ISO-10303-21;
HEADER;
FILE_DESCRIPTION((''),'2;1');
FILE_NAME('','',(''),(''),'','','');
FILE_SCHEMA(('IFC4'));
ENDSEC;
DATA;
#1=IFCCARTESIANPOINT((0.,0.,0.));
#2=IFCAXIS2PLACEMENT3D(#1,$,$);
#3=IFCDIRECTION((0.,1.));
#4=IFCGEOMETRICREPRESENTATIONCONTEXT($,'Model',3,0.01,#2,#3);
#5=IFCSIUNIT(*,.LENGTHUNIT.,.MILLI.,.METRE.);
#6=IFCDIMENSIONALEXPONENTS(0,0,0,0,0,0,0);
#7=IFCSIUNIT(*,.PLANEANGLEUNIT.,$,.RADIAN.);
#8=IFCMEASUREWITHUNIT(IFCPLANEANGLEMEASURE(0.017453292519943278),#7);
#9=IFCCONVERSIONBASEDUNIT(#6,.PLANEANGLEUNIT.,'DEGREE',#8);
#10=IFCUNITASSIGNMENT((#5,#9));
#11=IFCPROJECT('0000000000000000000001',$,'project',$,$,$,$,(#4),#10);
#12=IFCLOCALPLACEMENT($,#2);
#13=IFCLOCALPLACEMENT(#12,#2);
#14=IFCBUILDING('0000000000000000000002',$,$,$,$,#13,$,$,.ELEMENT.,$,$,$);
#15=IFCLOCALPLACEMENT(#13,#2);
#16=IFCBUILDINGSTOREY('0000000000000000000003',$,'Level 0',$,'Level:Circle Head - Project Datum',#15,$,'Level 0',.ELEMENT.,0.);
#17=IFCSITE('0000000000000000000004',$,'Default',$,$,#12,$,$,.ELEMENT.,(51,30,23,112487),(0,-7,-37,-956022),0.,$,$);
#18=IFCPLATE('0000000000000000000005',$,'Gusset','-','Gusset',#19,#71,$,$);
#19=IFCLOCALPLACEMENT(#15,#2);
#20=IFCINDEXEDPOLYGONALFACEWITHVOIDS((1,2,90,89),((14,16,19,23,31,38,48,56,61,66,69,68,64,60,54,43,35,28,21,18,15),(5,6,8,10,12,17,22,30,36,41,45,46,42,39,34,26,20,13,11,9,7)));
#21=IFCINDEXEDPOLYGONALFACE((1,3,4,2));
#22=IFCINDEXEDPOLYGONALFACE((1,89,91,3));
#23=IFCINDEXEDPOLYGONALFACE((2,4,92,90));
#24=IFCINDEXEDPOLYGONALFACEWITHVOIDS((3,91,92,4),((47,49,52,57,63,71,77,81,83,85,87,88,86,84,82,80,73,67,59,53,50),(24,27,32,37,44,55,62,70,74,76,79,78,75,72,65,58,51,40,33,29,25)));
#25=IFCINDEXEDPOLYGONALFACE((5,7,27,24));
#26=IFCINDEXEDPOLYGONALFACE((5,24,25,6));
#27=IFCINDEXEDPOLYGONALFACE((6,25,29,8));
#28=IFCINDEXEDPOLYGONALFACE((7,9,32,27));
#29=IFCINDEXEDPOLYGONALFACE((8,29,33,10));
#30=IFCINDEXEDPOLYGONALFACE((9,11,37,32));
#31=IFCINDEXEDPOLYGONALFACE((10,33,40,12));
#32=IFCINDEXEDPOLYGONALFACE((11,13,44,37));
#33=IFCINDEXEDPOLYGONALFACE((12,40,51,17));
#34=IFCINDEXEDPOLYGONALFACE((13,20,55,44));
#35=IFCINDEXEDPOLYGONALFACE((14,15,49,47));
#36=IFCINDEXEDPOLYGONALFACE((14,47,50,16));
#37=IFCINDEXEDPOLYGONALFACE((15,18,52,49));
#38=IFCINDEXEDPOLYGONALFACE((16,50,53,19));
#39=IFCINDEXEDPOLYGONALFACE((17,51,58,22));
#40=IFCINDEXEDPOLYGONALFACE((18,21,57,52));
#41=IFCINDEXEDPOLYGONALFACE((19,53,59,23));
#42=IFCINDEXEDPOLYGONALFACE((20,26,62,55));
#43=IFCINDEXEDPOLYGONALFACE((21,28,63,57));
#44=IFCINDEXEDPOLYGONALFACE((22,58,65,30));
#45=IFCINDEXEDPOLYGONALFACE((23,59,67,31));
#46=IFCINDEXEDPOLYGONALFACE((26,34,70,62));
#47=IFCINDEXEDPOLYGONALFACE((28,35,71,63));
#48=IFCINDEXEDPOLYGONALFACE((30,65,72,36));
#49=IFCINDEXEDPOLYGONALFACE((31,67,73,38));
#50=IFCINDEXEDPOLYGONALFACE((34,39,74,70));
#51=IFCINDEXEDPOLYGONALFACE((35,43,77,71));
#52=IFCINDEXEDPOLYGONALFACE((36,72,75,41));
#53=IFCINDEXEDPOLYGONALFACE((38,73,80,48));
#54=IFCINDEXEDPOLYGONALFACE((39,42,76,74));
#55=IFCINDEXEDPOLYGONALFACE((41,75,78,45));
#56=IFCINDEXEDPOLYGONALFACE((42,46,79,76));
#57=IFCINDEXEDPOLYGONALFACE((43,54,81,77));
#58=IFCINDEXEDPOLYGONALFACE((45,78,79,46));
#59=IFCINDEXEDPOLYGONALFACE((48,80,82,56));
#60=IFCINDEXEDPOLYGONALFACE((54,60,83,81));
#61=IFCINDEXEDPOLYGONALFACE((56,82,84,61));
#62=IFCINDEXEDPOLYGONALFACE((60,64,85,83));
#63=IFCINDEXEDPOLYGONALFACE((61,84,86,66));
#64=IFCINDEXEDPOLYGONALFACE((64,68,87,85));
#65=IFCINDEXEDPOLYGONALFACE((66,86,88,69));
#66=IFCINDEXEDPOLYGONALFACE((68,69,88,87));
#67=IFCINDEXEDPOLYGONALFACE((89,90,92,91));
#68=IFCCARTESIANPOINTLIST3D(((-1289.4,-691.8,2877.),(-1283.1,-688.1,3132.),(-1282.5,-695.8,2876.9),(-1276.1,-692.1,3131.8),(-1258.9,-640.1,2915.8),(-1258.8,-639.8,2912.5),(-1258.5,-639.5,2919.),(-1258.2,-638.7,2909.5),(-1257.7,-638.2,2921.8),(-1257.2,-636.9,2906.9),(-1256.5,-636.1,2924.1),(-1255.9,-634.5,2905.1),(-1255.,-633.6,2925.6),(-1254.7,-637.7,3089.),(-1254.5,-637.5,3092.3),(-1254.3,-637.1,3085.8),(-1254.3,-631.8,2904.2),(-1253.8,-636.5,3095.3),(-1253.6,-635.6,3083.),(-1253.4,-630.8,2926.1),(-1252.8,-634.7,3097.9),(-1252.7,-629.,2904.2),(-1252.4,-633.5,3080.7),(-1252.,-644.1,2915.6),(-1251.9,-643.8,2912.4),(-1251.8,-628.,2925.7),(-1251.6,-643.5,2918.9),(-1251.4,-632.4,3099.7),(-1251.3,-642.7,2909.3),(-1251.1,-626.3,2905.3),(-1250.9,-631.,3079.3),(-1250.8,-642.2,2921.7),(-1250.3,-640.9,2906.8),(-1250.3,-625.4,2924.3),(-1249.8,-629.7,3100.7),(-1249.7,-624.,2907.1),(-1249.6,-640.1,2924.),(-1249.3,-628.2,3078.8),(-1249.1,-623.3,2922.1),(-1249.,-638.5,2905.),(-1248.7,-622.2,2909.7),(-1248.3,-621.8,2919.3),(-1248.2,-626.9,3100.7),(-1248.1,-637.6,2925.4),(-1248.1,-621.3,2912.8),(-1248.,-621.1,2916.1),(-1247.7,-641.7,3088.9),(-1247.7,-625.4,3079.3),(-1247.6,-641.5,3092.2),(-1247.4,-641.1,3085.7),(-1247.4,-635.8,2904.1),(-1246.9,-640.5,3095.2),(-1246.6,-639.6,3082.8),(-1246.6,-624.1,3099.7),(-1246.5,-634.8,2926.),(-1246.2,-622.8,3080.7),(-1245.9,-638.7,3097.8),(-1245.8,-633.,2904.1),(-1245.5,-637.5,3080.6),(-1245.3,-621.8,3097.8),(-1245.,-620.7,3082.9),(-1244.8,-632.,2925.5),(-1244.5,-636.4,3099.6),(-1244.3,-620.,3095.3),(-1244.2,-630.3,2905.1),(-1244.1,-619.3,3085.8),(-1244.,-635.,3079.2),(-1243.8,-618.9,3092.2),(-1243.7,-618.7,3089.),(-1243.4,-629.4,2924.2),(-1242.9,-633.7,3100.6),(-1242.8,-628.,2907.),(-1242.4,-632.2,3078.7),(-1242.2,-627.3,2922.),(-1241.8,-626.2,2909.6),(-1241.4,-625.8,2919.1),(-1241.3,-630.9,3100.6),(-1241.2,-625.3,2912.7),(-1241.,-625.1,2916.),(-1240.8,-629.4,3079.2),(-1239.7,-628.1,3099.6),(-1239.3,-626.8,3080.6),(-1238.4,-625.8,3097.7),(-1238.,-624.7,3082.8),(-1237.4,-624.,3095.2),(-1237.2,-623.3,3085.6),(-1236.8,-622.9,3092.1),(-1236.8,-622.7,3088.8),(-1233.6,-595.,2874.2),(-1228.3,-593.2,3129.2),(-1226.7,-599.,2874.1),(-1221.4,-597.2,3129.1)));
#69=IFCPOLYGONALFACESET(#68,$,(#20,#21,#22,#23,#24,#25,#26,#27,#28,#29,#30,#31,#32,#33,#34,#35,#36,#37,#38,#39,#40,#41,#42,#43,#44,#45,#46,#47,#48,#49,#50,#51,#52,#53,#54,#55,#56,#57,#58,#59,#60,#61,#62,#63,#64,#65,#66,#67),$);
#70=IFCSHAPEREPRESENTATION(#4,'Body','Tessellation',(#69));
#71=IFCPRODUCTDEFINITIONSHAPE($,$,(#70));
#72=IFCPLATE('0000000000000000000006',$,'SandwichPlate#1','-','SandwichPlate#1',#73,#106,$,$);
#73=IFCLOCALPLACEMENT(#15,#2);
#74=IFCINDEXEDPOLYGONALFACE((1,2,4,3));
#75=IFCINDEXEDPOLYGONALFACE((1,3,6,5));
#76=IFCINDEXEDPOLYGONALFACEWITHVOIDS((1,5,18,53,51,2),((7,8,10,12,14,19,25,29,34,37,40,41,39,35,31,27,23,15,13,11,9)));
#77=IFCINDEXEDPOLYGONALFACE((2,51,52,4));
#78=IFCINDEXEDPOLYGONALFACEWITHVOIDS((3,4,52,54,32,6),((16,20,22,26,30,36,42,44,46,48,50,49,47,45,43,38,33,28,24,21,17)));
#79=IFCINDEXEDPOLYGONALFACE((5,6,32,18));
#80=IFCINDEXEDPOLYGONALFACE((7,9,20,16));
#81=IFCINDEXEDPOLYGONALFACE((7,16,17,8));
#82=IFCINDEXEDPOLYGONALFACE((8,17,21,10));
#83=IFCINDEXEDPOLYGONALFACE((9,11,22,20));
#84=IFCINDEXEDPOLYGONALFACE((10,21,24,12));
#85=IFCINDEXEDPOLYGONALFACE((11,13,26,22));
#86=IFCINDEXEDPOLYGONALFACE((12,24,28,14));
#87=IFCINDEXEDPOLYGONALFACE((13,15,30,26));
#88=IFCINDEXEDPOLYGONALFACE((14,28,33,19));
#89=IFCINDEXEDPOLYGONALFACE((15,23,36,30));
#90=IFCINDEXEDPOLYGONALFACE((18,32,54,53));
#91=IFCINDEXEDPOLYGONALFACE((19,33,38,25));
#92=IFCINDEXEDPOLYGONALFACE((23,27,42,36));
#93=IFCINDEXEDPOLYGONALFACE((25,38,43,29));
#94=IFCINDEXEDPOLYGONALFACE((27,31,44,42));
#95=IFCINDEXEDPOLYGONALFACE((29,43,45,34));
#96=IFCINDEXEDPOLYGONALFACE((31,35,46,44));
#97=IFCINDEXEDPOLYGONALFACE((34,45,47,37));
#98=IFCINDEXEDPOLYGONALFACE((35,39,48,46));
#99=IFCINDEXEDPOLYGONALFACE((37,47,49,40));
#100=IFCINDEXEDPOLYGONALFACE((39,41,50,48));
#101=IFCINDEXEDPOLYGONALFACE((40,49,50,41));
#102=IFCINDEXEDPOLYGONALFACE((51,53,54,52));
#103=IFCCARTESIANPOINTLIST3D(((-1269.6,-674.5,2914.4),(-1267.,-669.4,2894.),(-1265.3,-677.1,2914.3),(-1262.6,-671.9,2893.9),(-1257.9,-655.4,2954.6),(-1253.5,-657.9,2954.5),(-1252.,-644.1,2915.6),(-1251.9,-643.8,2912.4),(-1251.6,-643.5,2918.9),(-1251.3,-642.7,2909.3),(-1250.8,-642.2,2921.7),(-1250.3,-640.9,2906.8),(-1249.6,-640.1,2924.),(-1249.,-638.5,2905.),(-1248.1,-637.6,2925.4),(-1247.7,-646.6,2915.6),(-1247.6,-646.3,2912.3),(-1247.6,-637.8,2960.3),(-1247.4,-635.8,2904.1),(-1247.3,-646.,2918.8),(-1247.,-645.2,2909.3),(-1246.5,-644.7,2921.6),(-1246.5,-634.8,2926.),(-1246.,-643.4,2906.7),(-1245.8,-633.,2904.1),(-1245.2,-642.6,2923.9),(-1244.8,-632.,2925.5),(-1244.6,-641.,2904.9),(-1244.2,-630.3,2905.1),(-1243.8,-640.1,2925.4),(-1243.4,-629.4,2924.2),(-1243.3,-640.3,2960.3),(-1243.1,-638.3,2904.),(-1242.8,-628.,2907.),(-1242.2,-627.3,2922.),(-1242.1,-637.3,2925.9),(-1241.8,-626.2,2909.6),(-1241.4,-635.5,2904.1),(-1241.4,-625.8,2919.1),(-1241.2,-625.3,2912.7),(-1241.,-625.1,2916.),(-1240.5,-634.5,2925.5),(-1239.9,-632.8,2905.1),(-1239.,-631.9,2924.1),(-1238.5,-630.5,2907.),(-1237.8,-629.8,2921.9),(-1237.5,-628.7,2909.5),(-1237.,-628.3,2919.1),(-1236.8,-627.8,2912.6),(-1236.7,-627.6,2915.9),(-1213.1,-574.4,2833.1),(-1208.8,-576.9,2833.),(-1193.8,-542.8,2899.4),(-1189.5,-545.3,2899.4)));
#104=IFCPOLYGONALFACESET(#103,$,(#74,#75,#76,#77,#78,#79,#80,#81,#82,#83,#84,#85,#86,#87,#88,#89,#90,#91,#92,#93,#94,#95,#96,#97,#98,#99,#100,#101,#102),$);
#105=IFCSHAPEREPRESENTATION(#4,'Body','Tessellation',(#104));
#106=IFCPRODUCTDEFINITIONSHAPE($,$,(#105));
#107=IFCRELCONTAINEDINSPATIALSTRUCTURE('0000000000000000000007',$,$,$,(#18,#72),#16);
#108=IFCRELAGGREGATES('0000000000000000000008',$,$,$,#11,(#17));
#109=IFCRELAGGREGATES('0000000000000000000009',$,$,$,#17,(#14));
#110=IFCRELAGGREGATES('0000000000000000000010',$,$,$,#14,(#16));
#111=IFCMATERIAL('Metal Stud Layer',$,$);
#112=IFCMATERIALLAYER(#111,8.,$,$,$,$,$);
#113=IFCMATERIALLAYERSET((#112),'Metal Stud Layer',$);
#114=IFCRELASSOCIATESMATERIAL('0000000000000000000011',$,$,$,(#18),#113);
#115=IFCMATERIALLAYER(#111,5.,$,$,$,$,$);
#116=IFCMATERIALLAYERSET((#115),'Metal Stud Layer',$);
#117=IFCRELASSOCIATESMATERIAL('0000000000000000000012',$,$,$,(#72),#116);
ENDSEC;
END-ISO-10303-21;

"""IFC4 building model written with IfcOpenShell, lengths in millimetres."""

from ifc_helpers import new_model, entity, si_unit, converted_unit, direction, frame, origin, origin_with_axes, origin_2d_with_axis, place, context, project, spatial, polyline, circle, outline, extrude, material, layer, layer_set, element, save


model = new_model("IFC4")

# Units and contexts
model_context = context("Model", 3, precision=0.01, world=origin(), true_north=direction((0.0, 1.0)))
ifc_project = project(units=[si_unit("LENGTHUNIT", "METRE", prefix="MILLI"), converted_unit("PLANEANGLEUNIT", "DEGREE", entity("IfcPlaneAngleMeasure", 0.017453292519943278), si_unit("PLANEANGLEUNIT", "RADIAN"), dimensions=[0, 0, 0, 0, 0, 0, 0])], contexts=[model_context])

# Site, building, storey
site_placement = place(None, origin())
site = spatial("IfcSite", under=ifc_project, at=site_placement, Name="Default", CompositionType="ELEMENT", RefLatitude=(51, 30, 23, 112487), RefLongitude=(0, -7, -37, -956022), RefElevation=0.0)
building_placement = place(site_placement, origin())
building = spatial("IfcBuilding", under=site, at=building_placement, CompositionType="ELEMENT")
storey_placement = place(building_placement, origin())
storey = spatial("IfcBuildingStorey", under=building, at=storey_placement, Name="Level 0", ObjectType="Level:Circle Head - Project Datum", LongName="Level 0", CompositionType="ELEMENT", Elevation=0.0)

# Plates, openings
ifc_material_1 = material(Name="Metal Stud Layer")
ifc_layer_1 = layer(ifc_material_1, 8.0)
ifc_layer_set_1 = layer_set([ifc_layer_1], Name="Metal Stud Layer")
ifc_layer_2 = layer(ifc_material_1, 5.0)
ifc_layer_set_2 = layer_set([ifc_layer_2], Name="Metal Stud Layer")
plate_1_placement = place(storey_placement, frame((-1281.9, -686.2, 3131.9), z_axis=(0.865935, -0.499948, -0.014432), x_axis=(-0.02499, -0.014428, -0.999584)))
plate_1 = element("IfcPlate", 1, at=plate_1_placement, inside=storey, material=ifc_layer_set_1, Name="Gusset", Description="-", ObjectType="Gusset", context=model_context, shape_type="SweptSolid", body=[
    extrude(outline(polyline([(0.0, -2.3), (255.1, -2.3), (255.1, 109.5), (0.0, 107.4), (0.0, -2.3)])), origin_with_axes(), (0.0, 0.0, 1.0), 8.0),
])
opening_1_placement = place(plate_1_placement, frame((215.2, 67.8, 8.5), z_axis=(0.0, 0.0, -1.0), x_axis=(0.465435, 0.885082, 0.0)))
element("IfcOpeningElement", 2, at=opening_1_placement, cuts=plate_1, ObjectType="Opening", context=model_context, shape_type="SweptSolid", body=[
    extrude(circle(Radius=11.0, at=origin_2d_with_axis()), origin(), (0.0, 0.0, 1.0), 9.0),
])
opening_2_placement = place(plate_1_placement, frame((40.4, 67.6, 8.5), z_axis=(0.0, 0.0, -1.0), x_axis=(-0.519472, 0.854487, 0.0)))
element("IfcOpeningElement", 3, at=opening_2_placement, cuts=plate_1, ObjectType="Opening", context=model_context, shape_type="SweptSolid", body=[
    extrude(circle(Radius=11.0, at=origin_2d_with_axis()), origin(), (0.0, 0.0, 1.0), 9.0),
])
plate_2_placement = place(storey_placement, frame((-1269.1, -683.3, 2901.2), z_axis=(-0.865935, 0.499948, 0.014432), x_axis=(0.254617, 0.415806, 0.873084)))
plate_2 = element("IfcPlate", 4, at=plate_2_placement, inside=storey, material=ifc_layer_set_2, Name="SandwichPlate#1", Description="-", ObjectType="SandwichPlate#1", context=model_context, shape_type="SweptSolid", body=[
    extrude(outline(polyline([(0.0, 0.0), (76.0, 0.0), (76.0, 140.0), (0.0, 140.0), (0.0, 0.0)])), origin_with_axes(), (0.0, 0.0, 1.0), 5.0),
])
opening_3_placement = place(plate_2_placement, frame((0.0, 0.0, 0.0), z_axis=(0.0, 0.0, 1.0), x_axis=(1.0, 0.0, 0.0)))
element("IfcOpeningElement", 5, at=opening_3_placement, cuts=plate_2, ObjectType="Opening", context=model_context, shape_type="SweptSolid", body=[
    extrude(outline(polyline([(0.0, 0.0), (15.0, 0.0), (0.0, 15.0), (0.0, 0.0)])), origin(), (0.0, 0.0, 1.0), 5.0),
])
opening_4_placement = place(plate_2_placement, frame((0.0, 0.0, 0.0), z_axis=(0.0, 0.0, 1.0), x_axis=(1.0, 0.0, 0.0)))
element("IfcOpeningElement", 6, at=opening_4_placement, cuts=plate_2, ObjectType="Opening", context=model_context, shape_type="SweptSolid", body=[
    extrude(outline(polyline([(76.0, 0.0), (76.0, 15.0), (61.0, 0.0), (76.0, 0.0)])), origin(), (0.0, 0.0, 1.0), 5.0),
])
opening_5_placement = place(plate_2_placement, frame((38.0, 40.0, -0.5), z_axis=(0.0, 0.0, 1.0), x_axis=(0.0, 1.0, 0.0)))
element("IfcOpeningElement", 7, at=opening_5_placement, cuts=plate_2, ObjectType="Opening", context=model_context, shape_type="SweptSolid", body=[
    extrude(circle(Radius=11.0, at=origin_2d_with_axis()), origin(), (0.0, 0.0, 1.0), 6.0),
])

save(model, "model.ifc")
